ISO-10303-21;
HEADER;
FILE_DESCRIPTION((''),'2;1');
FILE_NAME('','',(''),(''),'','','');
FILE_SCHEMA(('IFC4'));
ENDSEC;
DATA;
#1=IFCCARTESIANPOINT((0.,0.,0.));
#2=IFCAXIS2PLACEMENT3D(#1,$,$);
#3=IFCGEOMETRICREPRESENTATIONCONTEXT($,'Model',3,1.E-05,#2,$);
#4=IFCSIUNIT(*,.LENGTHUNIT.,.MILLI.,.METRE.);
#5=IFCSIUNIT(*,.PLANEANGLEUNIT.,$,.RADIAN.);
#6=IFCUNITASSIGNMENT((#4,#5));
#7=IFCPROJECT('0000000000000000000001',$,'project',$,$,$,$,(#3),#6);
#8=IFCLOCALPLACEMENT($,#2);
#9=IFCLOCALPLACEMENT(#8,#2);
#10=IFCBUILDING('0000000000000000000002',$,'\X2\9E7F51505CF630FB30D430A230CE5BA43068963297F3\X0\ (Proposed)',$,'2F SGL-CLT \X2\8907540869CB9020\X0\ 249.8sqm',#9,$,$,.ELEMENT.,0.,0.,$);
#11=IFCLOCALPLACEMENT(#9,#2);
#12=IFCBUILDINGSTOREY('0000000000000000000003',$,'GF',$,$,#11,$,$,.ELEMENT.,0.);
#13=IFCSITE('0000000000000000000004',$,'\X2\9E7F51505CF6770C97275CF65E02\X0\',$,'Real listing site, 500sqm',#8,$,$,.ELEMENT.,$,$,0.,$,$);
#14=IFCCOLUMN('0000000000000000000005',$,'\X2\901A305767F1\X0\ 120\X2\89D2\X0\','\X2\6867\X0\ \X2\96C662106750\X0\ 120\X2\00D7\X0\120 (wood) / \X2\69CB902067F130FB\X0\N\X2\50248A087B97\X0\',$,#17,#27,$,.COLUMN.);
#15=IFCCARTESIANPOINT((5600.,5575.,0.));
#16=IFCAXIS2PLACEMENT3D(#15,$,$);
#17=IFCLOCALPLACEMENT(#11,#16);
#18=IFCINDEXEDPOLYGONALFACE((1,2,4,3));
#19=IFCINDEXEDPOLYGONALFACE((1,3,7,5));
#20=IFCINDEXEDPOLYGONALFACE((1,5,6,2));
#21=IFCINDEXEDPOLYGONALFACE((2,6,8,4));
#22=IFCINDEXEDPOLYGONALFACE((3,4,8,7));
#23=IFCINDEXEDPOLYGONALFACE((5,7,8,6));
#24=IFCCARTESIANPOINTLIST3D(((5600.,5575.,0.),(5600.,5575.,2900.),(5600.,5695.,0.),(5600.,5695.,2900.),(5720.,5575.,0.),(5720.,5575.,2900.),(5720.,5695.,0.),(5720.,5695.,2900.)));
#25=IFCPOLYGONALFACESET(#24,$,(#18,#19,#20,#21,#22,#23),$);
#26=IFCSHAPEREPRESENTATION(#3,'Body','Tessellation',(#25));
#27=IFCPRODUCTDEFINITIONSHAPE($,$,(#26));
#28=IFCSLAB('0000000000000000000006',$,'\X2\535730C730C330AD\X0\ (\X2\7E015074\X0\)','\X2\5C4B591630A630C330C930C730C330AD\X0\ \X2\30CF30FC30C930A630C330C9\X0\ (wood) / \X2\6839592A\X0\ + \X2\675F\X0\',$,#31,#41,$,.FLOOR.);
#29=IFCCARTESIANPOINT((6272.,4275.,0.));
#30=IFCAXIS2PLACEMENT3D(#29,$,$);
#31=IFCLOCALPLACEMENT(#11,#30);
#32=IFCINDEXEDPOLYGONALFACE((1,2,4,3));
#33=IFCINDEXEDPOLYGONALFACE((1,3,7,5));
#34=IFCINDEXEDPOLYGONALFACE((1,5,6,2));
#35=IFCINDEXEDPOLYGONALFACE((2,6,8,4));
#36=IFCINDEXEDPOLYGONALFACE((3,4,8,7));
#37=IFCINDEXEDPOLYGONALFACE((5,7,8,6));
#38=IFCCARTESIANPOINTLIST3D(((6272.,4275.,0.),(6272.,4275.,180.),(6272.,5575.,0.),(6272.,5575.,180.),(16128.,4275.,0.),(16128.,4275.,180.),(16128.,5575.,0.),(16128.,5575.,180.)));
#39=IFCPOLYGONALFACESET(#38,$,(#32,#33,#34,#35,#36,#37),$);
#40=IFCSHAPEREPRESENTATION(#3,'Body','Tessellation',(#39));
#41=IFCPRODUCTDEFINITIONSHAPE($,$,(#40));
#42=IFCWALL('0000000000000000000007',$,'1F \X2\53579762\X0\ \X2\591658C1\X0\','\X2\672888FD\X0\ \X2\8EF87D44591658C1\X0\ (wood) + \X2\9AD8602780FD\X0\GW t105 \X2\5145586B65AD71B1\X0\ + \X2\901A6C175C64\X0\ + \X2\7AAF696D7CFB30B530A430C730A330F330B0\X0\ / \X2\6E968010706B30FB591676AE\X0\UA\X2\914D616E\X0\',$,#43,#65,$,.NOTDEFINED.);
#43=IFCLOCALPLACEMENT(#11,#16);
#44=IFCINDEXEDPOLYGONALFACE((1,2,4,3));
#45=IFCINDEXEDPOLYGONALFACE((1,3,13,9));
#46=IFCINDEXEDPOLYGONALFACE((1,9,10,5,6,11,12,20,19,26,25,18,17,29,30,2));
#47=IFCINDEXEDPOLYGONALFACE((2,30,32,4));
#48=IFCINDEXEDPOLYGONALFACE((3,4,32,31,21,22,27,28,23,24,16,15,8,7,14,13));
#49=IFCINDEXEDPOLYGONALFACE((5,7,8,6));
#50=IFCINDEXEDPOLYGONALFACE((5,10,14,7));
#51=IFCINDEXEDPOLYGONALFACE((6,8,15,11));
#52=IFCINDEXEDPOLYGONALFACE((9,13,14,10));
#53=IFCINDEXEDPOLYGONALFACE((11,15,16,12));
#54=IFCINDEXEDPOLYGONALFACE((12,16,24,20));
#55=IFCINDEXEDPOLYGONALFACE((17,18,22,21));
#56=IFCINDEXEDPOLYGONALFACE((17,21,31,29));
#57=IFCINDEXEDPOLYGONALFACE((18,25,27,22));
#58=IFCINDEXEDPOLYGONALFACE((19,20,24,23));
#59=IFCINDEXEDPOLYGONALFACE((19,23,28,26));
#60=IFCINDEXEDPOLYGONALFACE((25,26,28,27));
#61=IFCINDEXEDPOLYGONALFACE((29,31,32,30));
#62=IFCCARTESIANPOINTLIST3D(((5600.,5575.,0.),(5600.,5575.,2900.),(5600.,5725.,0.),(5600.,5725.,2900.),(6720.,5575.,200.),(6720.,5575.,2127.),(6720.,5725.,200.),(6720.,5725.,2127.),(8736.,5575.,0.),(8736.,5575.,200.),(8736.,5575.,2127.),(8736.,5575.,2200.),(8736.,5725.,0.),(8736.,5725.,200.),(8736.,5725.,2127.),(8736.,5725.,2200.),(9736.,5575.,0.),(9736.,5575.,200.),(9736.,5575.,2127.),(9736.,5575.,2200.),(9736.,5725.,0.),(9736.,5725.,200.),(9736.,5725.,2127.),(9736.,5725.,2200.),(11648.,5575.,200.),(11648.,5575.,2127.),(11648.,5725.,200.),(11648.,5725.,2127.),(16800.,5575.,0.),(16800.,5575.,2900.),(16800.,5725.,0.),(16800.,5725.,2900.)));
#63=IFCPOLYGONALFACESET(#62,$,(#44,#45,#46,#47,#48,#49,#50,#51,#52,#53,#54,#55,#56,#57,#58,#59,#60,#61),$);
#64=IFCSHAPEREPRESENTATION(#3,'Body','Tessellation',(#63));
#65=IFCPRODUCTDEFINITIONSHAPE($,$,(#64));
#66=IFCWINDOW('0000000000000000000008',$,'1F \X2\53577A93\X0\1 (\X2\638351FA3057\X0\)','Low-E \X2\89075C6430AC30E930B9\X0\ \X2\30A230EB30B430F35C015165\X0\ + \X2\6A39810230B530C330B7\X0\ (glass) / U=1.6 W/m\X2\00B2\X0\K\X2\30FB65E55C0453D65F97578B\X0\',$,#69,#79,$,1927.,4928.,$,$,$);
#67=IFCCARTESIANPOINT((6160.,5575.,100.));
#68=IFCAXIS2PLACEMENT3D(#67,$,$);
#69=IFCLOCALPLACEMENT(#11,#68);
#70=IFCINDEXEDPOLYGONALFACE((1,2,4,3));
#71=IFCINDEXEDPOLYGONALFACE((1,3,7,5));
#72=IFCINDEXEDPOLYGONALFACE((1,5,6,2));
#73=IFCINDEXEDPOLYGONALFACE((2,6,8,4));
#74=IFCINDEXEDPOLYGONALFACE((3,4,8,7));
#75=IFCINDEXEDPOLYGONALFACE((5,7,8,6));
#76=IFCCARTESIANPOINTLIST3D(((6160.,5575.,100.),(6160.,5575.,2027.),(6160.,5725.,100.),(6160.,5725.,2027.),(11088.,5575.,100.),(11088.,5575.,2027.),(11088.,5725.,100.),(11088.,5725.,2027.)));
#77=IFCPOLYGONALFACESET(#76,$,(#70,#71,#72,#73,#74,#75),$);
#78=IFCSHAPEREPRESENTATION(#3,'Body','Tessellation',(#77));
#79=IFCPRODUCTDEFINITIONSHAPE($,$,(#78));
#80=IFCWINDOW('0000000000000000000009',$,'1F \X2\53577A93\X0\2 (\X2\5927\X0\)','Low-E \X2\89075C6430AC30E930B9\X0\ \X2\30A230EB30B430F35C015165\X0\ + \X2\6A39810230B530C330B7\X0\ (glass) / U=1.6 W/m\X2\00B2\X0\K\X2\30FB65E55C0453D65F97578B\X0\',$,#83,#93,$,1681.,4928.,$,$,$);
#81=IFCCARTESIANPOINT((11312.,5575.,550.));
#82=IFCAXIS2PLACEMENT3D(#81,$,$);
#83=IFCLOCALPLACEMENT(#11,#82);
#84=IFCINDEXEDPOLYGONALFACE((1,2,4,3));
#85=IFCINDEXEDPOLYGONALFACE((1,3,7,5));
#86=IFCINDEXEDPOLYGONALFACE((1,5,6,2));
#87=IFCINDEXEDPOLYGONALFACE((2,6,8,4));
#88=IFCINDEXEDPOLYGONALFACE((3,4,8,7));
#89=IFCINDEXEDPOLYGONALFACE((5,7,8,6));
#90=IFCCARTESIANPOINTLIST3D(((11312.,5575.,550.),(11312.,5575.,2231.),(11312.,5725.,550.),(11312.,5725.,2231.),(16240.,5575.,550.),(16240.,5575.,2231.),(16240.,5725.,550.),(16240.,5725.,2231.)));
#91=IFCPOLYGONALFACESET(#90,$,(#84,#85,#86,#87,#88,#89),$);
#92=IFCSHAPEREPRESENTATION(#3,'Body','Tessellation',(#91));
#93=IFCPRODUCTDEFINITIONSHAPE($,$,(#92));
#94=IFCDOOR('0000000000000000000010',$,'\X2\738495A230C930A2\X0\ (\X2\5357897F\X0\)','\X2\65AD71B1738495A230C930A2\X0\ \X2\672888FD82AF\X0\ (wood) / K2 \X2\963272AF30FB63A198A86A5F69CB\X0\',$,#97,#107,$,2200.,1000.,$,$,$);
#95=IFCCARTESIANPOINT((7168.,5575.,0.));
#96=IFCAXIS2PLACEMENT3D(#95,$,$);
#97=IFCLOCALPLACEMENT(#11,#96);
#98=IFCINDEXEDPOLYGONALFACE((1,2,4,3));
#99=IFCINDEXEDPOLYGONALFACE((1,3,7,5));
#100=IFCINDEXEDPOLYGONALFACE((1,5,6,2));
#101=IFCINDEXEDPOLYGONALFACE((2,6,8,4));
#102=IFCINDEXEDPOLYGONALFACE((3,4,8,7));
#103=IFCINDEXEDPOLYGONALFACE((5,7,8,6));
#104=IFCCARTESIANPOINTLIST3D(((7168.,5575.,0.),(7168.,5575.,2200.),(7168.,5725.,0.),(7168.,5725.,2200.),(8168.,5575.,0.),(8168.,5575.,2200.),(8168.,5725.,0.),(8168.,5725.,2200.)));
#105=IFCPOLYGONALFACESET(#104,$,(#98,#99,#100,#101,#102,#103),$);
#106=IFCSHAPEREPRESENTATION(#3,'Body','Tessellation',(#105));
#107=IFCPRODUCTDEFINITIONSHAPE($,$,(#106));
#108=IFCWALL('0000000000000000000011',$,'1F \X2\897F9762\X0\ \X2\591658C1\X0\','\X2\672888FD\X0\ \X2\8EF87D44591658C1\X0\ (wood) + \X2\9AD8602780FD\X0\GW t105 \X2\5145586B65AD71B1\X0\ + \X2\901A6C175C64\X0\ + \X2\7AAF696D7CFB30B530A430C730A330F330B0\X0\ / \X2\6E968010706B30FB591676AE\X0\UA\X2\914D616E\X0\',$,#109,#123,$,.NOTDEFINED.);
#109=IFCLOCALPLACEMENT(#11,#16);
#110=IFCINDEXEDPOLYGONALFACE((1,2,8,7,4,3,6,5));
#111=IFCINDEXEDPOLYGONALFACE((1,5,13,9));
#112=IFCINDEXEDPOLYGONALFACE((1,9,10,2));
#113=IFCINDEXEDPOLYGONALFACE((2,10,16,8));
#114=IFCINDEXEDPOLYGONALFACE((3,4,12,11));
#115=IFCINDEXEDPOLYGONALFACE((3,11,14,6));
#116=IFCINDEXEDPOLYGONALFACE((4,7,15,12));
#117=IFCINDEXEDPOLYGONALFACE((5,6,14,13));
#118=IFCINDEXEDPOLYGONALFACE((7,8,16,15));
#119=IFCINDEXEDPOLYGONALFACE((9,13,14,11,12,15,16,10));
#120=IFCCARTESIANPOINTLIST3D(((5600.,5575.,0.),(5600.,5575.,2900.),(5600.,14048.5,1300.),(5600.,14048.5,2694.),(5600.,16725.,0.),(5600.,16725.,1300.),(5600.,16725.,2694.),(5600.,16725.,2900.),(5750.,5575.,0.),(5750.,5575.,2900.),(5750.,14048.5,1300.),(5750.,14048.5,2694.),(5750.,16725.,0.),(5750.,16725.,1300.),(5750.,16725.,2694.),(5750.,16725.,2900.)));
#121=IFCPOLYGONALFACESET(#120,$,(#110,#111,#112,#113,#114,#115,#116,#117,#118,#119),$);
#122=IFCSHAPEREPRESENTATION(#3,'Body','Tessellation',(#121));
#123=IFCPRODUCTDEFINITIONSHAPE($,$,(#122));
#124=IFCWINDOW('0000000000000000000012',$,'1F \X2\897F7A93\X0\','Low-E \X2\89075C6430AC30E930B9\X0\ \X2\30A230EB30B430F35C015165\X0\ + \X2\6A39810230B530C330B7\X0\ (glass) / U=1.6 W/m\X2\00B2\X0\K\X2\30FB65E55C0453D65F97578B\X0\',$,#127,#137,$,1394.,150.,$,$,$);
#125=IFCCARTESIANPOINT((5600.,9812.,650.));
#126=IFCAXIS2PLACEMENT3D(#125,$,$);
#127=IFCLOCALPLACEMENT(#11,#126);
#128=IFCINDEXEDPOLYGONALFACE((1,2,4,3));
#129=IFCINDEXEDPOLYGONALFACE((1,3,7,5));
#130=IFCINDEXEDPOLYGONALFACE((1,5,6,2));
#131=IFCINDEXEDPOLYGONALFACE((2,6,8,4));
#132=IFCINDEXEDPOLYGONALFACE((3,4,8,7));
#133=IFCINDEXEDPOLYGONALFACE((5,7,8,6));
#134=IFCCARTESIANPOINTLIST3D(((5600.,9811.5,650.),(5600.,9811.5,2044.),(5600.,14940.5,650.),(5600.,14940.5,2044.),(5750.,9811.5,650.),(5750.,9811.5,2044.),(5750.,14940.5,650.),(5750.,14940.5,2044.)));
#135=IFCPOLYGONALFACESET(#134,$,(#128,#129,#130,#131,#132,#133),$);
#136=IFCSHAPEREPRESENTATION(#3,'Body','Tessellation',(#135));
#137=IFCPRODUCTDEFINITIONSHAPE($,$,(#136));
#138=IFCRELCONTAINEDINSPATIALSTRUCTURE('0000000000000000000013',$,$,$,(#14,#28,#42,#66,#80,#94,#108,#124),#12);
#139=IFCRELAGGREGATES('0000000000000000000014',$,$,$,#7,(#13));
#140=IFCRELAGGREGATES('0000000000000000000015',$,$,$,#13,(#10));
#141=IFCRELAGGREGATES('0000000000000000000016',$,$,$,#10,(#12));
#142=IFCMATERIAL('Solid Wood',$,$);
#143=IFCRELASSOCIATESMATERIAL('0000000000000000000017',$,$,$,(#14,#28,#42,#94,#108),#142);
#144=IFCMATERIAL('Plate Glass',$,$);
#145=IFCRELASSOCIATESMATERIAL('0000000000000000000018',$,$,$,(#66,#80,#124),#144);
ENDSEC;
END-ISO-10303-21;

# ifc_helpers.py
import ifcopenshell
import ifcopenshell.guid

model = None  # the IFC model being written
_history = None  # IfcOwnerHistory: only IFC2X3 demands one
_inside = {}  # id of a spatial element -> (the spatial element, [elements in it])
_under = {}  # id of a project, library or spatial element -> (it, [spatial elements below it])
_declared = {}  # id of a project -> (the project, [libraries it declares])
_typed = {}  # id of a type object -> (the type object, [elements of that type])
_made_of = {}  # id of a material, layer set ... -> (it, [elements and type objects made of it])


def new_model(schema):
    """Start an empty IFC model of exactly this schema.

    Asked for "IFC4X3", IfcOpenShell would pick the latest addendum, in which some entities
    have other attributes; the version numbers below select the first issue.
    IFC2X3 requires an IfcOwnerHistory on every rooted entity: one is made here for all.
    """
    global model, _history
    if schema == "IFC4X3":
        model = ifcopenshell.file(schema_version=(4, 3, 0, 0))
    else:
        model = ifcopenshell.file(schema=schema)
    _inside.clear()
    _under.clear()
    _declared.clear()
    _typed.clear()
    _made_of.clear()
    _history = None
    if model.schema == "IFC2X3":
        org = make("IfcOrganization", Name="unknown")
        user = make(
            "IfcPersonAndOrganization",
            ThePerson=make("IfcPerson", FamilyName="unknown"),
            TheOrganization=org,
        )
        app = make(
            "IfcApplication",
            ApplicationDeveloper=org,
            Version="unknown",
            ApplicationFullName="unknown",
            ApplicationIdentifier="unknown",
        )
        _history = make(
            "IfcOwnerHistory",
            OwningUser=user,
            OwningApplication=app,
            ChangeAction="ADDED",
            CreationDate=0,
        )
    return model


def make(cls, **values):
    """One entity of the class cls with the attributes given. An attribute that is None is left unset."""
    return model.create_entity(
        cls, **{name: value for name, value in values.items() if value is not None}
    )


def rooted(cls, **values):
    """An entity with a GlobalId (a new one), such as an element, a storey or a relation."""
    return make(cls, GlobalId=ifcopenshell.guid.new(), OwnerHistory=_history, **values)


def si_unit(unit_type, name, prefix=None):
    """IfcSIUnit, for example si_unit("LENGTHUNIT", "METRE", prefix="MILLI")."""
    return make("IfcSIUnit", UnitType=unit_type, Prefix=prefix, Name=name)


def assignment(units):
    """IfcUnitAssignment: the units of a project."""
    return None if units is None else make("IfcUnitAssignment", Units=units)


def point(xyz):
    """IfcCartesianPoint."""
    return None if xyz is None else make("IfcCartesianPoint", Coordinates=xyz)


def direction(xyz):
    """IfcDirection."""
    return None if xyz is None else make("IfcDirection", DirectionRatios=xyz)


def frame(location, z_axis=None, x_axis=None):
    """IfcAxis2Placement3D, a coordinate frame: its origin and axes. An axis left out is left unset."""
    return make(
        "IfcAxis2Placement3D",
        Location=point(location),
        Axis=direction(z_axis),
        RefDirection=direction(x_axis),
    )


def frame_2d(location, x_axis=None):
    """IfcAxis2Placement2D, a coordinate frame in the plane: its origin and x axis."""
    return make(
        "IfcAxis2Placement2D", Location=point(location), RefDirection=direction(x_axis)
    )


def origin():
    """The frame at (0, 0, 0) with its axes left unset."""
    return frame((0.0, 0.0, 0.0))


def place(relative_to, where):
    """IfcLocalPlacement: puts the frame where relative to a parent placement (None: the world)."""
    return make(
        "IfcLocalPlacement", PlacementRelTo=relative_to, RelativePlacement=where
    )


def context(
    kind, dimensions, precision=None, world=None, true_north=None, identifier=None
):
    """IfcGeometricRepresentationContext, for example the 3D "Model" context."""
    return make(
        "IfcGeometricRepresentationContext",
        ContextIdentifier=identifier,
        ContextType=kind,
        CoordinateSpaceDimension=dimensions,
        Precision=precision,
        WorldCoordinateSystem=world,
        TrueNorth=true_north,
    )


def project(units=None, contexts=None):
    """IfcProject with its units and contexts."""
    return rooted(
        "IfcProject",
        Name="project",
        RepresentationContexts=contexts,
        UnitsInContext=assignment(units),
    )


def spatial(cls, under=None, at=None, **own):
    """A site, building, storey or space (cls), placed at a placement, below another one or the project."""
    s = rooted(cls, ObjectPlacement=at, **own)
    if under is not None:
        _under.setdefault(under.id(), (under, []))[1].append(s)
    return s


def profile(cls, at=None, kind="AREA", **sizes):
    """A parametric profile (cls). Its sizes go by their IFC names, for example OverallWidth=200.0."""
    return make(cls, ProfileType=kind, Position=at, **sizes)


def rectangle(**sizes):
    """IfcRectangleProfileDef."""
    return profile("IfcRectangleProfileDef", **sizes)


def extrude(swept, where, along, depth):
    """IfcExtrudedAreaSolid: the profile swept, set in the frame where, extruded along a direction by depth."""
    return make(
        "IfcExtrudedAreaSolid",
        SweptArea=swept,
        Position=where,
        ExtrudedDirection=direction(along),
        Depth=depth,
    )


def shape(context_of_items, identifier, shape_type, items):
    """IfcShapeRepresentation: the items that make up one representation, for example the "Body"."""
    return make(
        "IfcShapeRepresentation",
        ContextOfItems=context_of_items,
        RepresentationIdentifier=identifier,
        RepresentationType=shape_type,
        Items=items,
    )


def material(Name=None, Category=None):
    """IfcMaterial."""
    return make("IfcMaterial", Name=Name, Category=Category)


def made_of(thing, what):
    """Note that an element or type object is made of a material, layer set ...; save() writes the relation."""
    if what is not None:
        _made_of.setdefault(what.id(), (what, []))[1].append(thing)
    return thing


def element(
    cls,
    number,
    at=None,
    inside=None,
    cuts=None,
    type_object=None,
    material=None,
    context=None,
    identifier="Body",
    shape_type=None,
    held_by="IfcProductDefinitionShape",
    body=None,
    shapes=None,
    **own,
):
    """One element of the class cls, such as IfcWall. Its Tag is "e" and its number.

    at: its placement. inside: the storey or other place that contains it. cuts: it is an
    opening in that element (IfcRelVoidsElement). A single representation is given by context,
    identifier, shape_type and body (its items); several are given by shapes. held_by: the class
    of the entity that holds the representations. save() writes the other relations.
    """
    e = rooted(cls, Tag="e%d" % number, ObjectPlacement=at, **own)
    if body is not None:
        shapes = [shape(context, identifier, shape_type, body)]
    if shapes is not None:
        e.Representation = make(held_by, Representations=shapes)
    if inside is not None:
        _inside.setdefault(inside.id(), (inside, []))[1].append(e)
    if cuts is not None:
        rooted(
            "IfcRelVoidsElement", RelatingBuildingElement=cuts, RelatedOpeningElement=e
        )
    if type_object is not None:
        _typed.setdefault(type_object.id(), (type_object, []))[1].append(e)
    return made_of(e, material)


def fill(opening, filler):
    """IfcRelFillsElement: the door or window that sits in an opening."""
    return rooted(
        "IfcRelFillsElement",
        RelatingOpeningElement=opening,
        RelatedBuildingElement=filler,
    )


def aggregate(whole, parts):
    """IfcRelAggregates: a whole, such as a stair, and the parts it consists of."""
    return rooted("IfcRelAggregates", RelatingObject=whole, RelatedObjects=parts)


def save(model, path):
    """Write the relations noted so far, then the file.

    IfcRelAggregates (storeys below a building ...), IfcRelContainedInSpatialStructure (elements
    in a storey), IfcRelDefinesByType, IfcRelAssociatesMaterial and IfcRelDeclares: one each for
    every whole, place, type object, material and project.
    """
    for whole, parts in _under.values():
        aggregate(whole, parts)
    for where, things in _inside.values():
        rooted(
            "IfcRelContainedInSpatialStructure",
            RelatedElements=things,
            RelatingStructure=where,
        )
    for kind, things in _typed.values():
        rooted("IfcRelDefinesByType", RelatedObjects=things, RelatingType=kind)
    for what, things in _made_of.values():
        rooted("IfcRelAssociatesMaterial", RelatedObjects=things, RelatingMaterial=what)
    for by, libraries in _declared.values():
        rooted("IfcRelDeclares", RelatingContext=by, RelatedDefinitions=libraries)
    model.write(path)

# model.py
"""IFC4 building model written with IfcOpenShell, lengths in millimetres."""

from ifc_helpers import new_model, si_unit, frame, frame_2d, origin, place, context, project, spatial, rectangle, extrude, material, element, fill, save


model = new_model("IFC4")

# Units and contexts
model_context = context("Model", 3, precision=1e-05, world=origin())
ifc_project = project(units=[si_unit("LENGTHUNIT", "METRE", prefix="MILLI"), si_unit("PLANEANGLEUNIT", "RADIAN")], contexts=[model_context])

# Site, building, storey
site_placement = place(None, origin())
site = spatial("IfcSite", under=ifc_project, at=site_placement, Name="鹿児島県霧島市", ObjectType="Real listing site, 500sqm", CompositionType="ELEMENT", RefElevation=0.0)
building_placement = place(site_placement, origin())
building = spatial("IfcBuilding", under=site, at=building_placement, Name="鹿児島・ピアノ室と防音 (Proposed)", ObjectType="2F SGL-CLT 複合構造 249.8sqm", CompositionType="ELEMENT", ElevationOfRefHeight=0.0, ElevationOfTerrain=0.0)
storey_placement = place(building_placement, origin())
storey = spatial("IfcBuildingStorey", under=building, at=storey_placement, Name="GF", CompositionType="ELEMENT", Elevation=0.0)

# Column
ifc_material_1 = material(Name="Solid Wood")
column_placement = place(storey_placement, frame((5600.0, 5575.0, 0.0)))
element("IfcColumn", 1, at=column_placement, inside=storey, material=ifc_material_1, Name="通し柱 120角", Description="桧 集成材 120×120 (wood) / 構造柱・N値計算", PredefinedType="COLUMN", context=model_context, shape_type="SweptSolid", body=[
    extrude(rectangle(XDim=120.0, YDim=120.0, at=frame_2d((60.0, 60.0))), frame((5600.0, 5575.0, 0.0)), (0.0, 0.0, 1.0), 2900.0),
])

# Slab
slab_1_placement = place(storey_placement, frame((6272.0, 4275.0, 0.0)))
element("IfcSlab", 2, at=slab_1_placement, inside=storey, material=ifc_material_1, Name="南デッキ (縁側)", Description="屋外ウッドデッキ ハードウッド (wood) / 根太 + 束", PredefinedType="FLOOR", context=model_context, shape_type="SweptSolid", body=[
    extrude(rectangle(XDim=9856.0, YDim=1300.0, at=frame_2d((4928.0, 650.0))), frame((6272.0, 4275.0, 0.0)), (0.0, 0.0, 1.0), 180.0),
])

# Wall, openings, windows, door
wall_1_placement = place(storey_placement, frame((5600.0, 5575.0, 0.0)))
wall_1 = element("IfcWall", 3, at=wall_1_placement, inside=storey, material=ifc_material_1, Name="1F 南面 外壁", Description="木製 軸組外壁 (wood) + 高性能GW t105 充填断熱 + 通気層 + 窯業系サイディング / 準耐火・外皮UA配慮", PredefinedType="NOTDEFINED", context=model_context, shape_type="SweptSolid", body=[
    extrude(rectangle(XDim=11200.0, YDim=150.0, at=frame_2d((5600.0, 75.0))), frame((5600.0, 5575.0, 0.0)), (0.0, 0.0, 1.0), 2900.0),
])
opening_1_placement = place(storey_placement, frame((6160.0, 5575.0, 100.0)))
opening_1 = element("IfcOpeningElement", 4, at=opening_1_placement, cuts=wall_1, PredefinedType="NOTDEFINED", context=model_context, shape_type="SweptSolid", body=[
    extrude(rectangle(XDim=4928.0, YDim=150.0, at=frame_2d((2464.0, 75.0))), frame((6160.0, 5575.0, 100.0)), (0.0, 0.0, 1.0), 1927.0),
])
opening_2_placement = place(storey_placement, frame((11312.0, 5575.0, 550.0)))
opening_2 = element("IfcOpeningElement", 5, at=opening_2_placement, cuts=wall_1, PredefinedType="NOTDEFINED", context=model_context, shape_type="SweptSolid", body=[
    extrude(rectangle(XDim=4928.0, YDim=150.0, at=frame_2d((2464.0, 75.0))), frame((11312.0, 5575.0, 550.0)), (0.0, 0.0, 1.0), 1681.0),
])
opening_3_placement = place(storey_placement, frame((7168.0, 5575.0, 0.0)))
opening_3 = element("IfcOpeningElement", 6, at=opening_3_placement, cuts=wall_1, PredefinedType="NOTDEFINED", context=model_context, shape_type="SweptSolid", body=[
    extrude(rectangle(XDim=1000.0, YDim=150.0, at=frame_2d((500.0, 75.0))), frame((7168.0, 5575.0, 0.0)), (0.0, 0.0, 1.0), 2200.0),
])
ifc_material_2 = material(Name="Plate Glass")
window_1_placement = place(storey_placement, frame((6160.0, 5575.0, 100.0)))
window_1 = element("IfcWindow", 7, at=window_1_placement, inside=storey, material=ifc_material_2, Name="1F 南窓1 (掃出し)", Description="Low-E 複層ガラス アルゴン封入 + 樹脂サッシ (glass) / U=1.6 W/m²K・日射取得型", OverallHeight=1927.0, OverallWidth=4928.0, context=model_context, shape_type="SweptSolid", body=[
    extrude(rectangle(XDim=4928.0, YDim=150.0, at=frame_2d((2464.0, 75.0))), frame((6160.0, 5575.0, 100.0)), (0.0, 0.0, 1.0), 1927.0),
])
fill(opening_1, window_1)
window_2_placement = place(storey_placement, frame((11312.0, 5575.0, 550.0)))
window_2 = element("IfcWindow", 8, at=window_2_placement, inside=storey, material=ifc_material_2, Name="1F 南窓2 (大)", Description="Low-E 複層ガラス アルゴン封入 + 樹脂サッシ (glass) / U=1.6 W/m²K・日射取得型", OverallHeight=1681.0, OverallWidth=4928.0, context=model_context, shape_type="SweptSolid", body=[
    extrude(rectangle(XDim=4928.0, YDim=150.0, at=frame_2d((2464.0, 75.0))), frame((11312.0, 5575.0, 550.0)), (0.0, 0.0, 1.0), 1681.0),
])
fill(opening_2, window_2)
door_placement = place(storey_placement, frame((7168.0, 5575.0, 0.0)))
door = element("IfcDoor", 9, at=door_placement, inside=storey, material=ifc_material_1, Name="玄関ドア (南西)", Description="断熱玄関ドア 木製芯 (wood) / K2 防犯・採風機構", OverallHeight=2200.0, OverallWidth=1000.0, context=model_context, shape_type="SweptSolid", body=[
    extrude(rectangle(XDim=1000.0, YDim=150.0, at=frame_2d((500.0, 75.0))), frame((7168.0, 5575.0, 0.0)), (0.0, 0.0, 1.0), 2200.0),
])
fill(opening_3, door)

# Wall, opening, window
wall_2_placement = place(storey_placement, frame((5600.0, 5575.0, 0.0)))
wall_2 = element("IfcWall", 10, at=wall_2_placement, inside=storey, material=ifc_material_1, Name="1F 西面 外壁", Description="木製 軸組外壁 (wood) + 高性能GW t105 充填断熱 + 通気層 + 窯業系サイディング / 準耐火・外皮UA配慮", PredefinedType="NOTDEFINED", context=model_context, shape_type="SweptSolid", body=[
    extrude(rectangle(XDim=150.0, YDim=11150.0, at=frame_2d((75.0, 5575.0))), frame((5600.0, 5575.0, 0.0)), (0.0, 0.0, 1.0), 2900.0),
])
opening_4_placement = place(storey_placement, frame((5600.0, 9812.0, 650.0)))
opening_4 = element("IfcOpeningElement", 11, at=opening_4_placement, cuts=wall_2, PredefinedType="NOTDEFINED", context=model_context, shape_type="SweptSolid", body=[
    extrude(rectangle(XDim=150.0, YDim=5129.0, at=frame_2d((75.0, 2564.0))), frame((5600.0, 9812.0, 650.0)), (0.0, 0.0, 1.0), 1394.0),
])
window_3_placement = place(storey_placement, frame((5600.0, 9812.0, 650.0)))
window_3 = element("IfcWindow", 12, at=window_3_placement, inside=storey, material=ifc_material_2, Name="1F 西窓", Description="Low-E 複層ガラス アルゴン封入 + 樹脂サッシ (glass) / U=1.6 W/m²K・日射取得型", OverallHeight=1394.0, OverallWidth=150.0, context=model_context, shape_type="SweptSolid", body=[
    extrude(rectangle(XDim=150.0, YDim=5129.0, at=frame_2d((75.0, 2564.0))), frame((5600.0, 9812.0, 650.0)), (0.0, 0.0, 1.0), 1394.0),
])
fill(opening_4, window_3)

save(model, "model.ifc")
